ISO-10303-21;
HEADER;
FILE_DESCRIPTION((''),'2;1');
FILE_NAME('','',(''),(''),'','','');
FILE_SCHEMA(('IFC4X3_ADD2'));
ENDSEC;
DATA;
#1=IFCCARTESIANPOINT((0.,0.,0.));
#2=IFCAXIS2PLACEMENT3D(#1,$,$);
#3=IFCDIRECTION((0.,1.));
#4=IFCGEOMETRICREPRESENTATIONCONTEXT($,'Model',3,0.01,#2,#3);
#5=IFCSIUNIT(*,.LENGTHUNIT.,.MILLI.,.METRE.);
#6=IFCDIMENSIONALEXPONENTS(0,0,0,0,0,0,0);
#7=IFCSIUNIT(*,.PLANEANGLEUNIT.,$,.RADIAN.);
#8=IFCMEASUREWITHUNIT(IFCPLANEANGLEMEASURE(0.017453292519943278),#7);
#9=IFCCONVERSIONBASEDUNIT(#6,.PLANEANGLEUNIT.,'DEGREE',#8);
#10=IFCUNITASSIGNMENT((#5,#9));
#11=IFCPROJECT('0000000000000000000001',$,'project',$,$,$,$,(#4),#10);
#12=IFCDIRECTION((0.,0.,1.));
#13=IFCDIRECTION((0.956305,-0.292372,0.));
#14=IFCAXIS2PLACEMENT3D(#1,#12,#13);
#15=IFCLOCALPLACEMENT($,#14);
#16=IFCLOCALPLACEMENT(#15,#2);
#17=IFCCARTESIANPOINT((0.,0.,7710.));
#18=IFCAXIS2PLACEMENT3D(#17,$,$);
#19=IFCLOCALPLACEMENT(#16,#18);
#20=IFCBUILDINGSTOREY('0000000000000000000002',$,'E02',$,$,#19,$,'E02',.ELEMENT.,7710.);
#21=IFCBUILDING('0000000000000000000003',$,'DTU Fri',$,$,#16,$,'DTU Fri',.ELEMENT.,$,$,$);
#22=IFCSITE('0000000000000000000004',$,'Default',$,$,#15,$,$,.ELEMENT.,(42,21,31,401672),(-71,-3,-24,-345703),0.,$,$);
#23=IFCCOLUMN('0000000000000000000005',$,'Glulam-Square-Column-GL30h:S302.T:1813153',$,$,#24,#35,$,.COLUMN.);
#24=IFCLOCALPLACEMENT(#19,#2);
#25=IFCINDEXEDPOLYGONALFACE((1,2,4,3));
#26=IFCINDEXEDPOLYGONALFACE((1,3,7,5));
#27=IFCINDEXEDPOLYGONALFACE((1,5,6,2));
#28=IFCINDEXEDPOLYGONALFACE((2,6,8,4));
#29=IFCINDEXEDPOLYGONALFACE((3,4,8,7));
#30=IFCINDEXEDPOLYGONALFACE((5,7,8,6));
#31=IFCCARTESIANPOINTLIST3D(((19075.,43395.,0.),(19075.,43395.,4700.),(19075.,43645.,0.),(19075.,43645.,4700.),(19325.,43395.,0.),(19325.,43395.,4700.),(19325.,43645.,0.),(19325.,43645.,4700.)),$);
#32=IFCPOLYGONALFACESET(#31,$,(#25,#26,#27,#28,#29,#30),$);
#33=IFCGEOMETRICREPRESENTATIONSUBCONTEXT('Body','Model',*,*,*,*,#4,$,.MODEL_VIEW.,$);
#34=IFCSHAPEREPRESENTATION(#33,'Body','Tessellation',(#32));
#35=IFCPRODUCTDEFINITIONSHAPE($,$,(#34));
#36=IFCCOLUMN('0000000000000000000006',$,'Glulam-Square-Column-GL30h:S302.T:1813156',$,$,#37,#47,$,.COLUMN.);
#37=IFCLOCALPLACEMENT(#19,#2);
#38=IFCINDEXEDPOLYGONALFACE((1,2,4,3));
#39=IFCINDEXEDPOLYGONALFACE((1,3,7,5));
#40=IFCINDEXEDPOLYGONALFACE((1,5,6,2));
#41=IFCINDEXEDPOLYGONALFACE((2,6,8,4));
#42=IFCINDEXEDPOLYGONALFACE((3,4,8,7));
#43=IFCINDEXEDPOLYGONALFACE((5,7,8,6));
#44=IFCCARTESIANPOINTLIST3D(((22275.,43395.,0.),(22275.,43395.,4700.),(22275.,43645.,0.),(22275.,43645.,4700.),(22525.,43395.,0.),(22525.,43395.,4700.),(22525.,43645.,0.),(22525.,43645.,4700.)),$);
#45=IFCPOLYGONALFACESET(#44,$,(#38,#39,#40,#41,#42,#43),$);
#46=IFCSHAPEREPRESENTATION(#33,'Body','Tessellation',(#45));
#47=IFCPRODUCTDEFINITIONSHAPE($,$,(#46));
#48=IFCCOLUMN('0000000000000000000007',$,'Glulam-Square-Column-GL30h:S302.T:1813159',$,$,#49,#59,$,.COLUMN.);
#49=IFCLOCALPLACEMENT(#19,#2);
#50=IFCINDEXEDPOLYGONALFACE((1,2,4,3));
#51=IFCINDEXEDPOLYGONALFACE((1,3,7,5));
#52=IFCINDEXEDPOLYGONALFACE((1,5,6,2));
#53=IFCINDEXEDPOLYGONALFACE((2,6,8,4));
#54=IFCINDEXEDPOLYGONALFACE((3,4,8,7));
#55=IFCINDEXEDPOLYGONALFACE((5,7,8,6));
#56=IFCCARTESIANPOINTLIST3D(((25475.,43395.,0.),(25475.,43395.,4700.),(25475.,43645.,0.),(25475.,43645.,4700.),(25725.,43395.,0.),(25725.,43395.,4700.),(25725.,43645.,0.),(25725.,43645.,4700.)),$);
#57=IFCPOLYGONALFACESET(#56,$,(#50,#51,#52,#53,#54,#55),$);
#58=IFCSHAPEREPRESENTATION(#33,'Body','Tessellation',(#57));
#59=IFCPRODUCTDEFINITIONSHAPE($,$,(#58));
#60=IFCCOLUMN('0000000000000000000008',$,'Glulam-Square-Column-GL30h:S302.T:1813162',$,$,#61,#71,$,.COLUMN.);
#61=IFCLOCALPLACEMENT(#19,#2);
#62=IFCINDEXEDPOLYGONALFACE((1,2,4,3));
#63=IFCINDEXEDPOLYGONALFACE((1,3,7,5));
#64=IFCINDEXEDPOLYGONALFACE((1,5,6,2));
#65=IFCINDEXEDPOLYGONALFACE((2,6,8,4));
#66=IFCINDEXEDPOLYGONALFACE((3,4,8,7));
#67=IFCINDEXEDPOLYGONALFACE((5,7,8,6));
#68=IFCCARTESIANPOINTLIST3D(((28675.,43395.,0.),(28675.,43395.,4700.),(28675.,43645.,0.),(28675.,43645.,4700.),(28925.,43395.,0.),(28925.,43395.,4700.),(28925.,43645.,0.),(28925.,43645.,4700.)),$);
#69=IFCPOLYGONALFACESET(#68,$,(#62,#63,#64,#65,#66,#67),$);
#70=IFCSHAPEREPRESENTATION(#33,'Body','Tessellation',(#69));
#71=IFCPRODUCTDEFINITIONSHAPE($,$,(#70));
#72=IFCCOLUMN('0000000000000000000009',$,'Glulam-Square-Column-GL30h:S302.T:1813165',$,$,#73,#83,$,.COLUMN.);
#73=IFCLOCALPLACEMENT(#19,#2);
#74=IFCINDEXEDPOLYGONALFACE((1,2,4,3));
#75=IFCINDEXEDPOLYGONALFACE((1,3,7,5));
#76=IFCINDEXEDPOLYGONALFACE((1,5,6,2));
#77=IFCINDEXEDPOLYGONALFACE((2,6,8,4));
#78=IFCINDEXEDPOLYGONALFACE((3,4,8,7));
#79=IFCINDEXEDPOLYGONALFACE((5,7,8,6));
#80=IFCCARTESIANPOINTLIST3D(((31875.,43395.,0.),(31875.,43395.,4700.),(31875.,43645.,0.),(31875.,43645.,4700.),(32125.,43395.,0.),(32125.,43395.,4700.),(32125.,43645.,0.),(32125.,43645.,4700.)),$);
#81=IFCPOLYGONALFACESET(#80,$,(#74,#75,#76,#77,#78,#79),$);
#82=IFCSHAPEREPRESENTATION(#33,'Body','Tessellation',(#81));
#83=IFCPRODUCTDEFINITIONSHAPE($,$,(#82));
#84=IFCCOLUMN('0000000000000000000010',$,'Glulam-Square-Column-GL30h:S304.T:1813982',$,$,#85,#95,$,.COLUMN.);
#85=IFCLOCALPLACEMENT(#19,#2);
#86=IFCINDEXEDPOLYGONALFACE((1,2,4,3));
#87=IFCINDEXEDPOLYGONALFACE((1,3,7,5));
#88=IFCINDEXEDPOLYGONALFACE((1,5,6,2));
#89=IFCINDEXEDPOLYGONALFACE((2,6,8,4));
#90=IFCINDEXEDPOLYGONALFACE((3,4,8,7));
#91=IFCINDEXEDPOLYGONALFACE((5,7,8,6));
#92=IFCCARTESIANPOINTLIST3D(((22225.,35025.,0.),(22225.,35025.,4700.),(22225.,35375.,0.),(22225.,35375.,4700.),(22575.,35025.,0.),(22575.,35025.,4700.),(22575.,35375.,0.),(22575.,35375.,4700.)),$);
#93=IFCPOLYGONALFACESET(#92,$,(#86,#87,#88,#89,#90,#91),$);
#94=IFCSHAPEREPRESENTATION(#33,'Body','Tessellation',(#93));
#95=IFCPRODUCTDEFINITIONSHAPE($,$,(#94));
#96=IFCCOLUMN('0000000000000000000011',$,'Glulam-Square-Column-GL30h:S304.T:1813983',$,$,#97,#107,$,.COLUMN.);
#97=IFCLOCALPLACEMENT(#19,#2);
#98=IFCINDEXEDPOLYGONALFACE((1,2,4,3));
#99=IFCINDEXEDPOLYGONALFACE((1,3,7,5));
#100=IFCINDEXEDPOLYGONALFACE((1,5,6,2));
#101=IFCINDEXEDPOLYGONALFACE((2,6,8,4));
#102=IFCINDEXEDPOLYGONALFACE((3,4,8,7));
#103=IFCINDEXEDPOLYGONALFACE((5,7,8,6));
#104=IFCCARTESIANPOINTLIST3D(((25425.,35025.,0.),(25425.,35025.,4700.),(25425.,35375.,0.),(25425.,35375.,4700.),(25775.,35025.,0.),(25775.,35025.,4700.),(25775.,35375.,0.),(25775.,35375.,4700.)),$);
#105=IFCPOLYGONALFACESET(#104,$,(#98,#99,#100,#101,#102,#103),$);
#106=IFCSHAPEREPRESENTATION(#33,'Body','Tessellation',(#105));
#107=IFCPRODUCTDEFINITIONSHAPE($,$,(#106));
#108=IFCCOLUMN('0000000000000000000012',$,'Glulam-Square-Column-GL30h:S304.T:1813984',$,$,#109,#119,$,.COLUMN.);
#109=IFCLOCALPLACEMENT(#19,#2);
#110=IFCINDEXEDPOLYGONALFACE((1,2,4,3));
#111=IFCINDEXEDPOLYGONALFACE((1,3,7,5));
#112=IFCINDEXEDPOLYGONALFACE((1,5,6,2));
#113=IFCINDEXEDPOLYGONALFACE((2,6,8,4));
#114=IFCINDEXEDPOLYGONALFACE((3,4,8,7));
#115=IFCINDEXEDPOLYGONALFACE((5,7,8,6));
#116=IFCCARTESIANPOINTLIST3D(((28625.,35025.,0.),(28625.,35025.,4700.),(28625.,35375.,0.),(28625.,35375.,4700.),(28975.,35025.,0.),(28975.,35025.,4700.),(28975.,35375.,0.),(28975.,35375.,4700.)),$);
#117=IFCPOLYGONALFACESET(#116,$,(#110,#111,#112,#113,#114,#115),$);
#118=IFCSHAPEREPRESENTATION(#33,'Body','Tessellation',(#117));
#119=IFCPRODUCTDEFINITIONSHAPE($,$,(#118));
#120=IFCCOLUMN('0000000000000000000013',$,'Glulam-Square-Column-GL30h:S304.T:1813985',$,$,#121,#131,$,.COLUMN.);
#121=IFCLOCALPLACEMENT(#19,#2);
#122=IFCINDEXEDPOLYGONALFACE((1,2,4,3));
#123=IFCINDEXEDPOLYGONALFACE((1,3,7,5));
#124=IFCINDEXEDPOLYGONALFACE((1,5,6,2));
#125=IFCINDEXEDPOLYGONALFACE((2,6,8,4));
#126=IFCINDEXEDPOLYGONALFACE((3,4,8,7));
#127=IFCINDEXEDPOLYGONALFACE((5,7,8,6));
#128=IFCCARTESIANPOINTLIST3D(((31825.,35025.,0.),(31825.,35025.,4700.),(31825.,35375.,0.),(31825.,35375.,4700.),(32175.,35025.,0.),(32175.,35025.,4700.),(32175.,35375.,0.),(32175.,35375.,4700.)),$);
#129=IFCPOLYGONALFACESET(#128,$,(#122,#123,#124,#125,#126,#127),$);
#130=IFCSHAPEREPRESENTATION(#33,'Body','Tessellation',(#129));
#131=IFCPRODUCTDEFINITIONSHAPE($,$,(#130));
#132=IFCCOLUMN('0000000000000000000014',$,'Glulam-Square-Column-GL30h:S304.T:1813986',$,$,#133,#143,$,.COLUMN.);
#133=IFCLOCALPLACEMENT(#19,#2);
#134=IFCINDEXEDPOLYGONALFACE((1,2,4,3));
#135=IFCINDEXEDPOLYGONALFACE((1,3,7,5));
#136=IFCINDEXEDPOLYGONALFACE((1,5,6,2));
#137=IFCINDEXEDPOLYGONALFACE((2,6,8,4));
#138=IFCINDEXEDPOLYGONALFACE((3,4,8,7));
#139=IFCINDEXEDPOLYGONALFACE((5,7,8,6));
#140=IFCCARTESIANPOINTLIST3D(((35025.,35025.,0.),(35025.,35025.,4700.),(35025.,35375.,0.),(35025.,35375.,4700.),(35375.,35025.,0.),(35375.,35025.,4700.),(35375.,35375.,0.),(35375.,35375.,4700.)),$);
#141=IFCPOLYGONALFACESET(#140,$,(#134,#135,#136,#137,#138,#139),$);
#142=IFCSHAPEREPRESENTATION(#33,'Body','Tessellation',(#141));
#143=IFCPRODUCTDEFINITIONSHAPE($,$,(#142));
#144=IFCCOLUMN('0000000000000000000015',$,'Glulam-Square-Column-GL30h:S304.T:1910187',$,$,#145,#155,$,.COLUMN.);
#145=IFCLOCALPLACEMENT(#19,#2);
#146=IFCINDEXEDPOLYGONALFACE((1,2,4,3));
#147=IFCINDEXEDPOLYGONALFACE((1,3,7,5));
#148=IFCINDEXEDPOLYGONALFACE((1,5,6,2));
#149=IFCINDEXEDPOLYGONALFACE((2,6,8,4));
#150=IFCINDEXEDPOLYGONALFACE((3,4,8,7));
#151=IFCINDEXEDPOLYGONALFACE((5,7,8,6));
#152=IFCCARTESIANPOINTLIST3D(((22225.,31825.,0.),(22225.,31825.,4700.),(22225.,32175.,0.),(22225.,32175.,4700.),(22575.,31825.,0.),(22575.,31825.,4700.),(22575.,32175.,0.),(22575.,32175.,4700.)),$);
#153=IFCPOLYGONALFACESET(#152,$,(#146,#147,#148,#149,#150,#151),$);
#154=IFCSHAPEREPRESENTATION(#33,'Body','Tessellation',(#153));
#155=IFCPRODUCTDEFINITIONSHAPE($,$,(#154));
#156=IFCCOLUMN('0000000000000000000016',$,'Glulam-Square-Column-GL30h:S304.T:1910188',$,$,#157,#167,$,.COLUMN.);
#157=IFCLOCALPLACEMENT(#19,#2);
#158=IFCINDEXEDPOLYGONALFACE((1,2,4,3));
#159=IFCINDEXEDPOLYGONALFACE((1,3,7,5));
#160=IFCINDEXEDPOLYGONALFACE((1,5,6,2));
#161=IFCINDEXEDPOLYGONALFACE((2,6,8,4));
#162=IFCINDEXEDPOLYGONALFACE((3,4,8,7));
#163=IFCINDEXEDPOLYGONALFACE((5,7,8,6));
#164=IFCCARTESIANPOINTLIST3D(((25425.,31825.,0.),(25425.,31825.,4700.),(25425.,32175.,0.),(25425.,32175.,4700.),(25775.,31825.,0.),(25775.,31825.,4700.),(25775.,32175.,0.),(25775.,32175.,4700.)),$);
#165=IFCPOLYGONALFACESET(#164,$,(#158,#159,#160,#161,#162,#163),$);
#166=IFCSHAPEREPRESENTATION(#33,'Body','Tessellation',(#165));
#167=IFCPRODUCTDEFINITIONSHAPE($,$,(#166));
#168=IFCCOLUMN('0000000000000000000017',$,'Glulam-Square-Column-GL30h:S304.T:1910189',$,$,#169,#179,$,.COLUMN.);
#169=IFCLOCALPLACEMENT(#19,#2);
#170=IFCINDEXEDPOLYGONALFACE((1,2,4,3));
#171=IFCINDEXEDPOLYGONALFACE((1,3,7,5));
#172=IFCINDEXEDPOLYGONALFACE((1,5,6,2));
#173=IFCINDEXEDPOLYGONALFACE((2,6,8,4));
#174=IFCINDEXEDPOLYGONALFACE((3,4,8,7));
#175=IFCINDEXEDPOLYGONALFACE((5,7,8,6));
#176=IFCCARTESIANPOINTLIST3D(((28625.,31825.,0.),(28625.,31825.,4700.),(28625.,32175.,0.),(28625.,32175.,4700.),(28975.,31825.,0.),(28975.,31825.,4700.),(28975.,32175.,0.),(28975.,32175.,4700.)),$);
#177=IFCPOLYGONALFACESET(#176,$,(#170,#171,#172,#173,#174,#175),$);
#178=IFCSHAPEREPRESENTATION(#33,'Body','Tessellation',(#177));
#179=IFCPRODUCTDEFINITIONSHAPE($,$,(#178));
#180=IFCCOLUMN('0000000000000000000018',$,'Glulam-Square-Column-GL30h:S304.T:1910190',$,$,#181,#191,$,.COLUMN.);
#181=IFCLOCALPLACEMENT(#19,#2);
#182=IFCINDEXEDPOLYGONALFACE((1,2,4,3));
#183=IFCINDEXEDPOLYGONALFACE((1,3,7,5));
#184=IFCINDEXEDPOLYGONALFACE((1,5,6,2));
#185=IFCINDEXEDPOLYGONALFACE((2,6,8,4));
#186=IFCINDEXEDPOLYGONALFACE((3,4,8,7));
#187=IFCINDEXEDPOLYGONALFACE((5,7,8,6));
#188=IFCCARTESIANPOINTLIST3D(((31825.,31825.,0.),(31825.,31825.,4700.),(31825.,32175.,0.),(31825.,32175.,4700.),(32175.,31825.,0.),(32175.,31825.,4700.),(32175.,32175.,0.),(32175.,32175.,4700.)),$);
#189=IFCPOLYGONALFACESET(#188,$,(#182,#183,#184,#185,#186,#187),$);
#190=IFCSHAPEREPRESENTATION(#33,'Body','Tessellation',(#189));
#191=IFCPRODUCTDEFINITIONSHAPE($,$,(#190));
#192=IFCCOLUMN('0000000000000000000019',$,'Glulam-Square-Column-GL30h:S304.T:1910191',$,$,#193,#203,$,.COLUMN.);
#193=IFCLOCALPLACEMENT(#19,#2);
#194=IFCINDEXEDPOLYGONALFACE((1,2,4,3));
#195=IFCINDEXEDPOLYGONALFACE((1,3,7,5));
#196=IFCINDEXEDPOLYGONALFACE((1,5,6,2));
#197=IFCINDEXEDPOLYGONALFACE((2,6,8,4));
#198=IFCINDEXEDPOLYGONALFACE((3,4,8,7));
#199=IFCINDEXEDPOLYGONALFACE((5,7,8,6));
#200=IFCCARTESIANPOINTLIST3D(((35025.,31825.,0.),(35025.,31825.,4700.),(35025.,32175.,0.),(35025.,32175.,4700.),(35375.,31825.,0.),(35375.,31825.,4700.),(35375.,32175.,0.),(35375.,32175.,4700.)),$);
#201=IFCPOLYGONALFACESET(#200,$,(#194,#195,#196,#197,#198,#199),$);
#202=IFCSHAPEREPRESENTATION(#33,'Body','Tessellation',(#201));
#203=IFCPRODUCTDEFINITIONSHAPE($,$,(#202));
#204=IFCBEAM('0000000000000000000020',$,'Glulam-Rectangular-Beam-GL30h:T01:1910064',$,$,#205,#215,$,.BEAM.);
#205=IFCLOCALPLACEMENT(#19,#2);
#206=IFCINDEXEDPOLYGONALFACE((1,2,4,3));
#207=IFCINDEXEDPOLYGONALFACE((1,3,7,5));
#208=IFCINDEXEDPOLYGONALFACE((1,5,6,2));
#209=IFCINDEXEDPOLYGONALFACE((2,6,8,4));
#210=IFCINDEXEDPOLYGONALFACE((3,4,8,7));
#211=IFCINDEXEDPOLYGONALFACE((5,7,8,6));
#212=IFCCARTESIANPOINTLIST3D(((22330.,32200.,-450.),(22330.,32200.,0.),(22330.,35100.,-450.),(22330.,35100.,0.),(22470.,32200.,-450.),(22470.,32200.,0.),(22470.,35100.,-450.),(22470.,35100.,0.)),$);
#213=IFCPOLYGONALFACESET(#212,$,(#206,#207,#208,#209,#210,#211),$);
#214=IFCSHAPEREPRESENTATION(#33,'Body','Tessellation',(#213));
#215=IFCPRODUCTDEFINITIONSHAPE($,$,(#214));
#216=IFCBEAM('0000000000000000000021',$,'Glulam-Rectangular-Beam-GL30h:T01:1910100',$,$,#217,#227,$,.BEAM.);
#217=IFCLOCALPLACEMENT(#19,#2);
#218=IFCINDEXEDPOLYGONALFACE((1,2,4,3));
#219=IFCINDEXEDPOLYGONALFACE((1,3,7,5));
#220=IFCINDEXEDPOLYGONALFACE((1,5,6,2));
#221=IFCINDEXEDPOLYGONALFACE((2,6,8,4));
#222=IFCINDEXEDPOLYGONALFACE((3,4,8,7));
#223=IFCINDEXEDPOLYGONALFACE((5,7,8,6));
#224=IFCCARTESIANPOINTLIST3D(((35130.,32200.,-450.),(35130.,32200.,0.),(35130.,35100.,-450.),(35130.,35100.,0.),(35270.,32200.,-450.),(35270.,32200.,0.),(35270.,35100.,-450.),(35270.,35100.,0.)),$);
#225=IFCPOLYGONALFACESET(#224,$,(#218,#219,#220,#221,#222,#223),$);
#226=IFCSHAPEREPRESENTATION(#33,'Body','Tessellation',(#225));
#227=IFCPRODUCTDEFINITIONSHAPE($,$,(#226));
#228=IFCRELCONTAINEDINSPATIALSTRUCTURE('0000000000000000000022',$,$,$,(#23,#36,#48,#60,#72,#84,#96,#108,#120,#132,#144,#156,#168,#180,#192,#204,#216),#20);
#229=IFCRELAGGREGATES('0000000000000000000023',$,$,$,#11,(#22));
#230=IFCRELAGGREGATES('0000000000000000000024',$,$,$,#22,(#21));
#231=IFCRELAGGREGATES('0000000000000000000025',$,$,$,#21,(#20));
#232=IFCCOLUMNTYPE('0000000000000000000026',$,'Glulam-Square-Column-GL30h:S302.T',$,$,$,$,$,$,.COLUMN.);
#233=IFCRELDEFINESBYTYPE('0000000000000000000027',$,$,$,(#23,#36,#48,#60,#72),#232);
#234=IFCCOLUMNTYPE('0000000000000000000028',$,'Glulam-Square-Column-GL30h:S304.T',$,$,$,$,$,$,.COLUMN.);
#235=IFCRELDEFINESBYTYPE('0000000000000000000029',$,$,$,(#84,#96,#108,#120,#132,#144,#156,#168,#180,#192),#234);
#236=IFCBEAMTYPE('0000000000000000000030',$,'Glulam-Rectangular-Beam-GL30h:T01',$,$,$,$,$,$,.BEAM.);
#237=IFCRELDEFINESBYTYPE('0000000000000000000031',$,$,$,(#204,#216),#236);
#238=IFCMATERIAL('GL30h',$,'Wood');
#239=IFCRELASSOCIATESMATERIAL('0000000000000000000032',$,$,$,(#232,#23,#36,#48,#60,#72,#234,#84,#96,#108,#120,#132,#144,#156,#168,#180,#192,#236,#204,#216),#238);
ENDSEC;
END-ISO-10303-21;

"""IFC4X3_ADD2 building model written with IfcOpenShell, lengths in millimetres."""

from ifc_helpers import new_model, entity, si_unit, converted_unit, direction, frame, origin, origin_2d_with_axis, place, context, subcontext, project, spatial, rectangle, extrude, source, transform, mapped, material, material_profile, profile_set, profile_usage, type_object, type_shapes, element, save


model = new_model("IFC4X3_ADD2")

# Units and contexts
model_context = context("Model", 3, precision=0.01, world=origin(), true_north=direction((0.0, 1.0)))
body_context = subcontext(model_context, "Body", "Model", "MODEL_VIEW")
ifc_project = project(units=[si_unit("LENGTHUNIT", "METRE", prefix="MILLI"), converted_unit("PLANEANGLEUNIT", "DEGREE", entity("IfcPlaneAngleMeasure", 0.017453292519943278), si_unit("PLANEANGLEUNIT", "RADIAN"), dimensions=[0, 0, 0, 0, 0, 0, 0])], contexts=[model_context])

# Site, building, storey
site_placement = place(None, frame((0.0, 0.0, 0.0), z_axis=(0.0, 0.0, 1.0), x_axis=(0.956305, -0.292372, 0.0)))
site = spatial("IfcSite", under=ifc_project, at=site_placement, Name="Default", CompositionType="ELEMENT", RefLatitude=(42, 21, 31, 401672), RefLongitude=(-71, -3, -24, -345703), RefElevation=0.0)
building_placement = place(site_placement, origin())
building = spatial("IfcBuilding", under=site, at=building_placement, Name="DTU Fri", LongName="DTU Fri", CompositionType="ELEMENT")
storey_placement = place(building_placement, frame((0.0, 0.0, 7710.0)))
storey = spatial("IfcBuildingStorey", under=building, at=storey_placement, Name="E02", LongName="E02", CompositionType="ELEMENT", Elevation=7710.0)

# Columns
ifc_material_1 = material(Name="GL30h", Category="Wood")
ifc_material_profile_1 = material_profile(ifc_material_1, rectangle(XDim=250.0, YDim=250.0, at=origin_2d_with_axis()), Name="S302.T")
ifc_profile_set_1 = profile_set([ifc_material_profile_1], Name="S302.T")
ifc_profile_usage_1 = profile_usage(ifc_profile_set_1)
column_type_1 = type_object("IfcColumnType", Name="Glulam-Square-Column-GL30h:S302.T", PredefinedType="COLUMN", material=ifc_profile_set_1)
shared_shape_1 = source(origin(), body_context, "Body", "SweptSolid", [
    extrude(rectangle(XDim=250.0, YDim=250.0, at=origin_2d_with_axis()), frame((0.0, 0.0, 7710.0), z_axis=(0.0, 0.0, 1.0), x_axis=(0.0, 1.0, 0.0)), (0.0, 0.0, 1.0), 4700.0),
])
type_shapes(column_type_1, [shared_shape_1])
for number, where, name in (
    (1, (19200.0, 43520.0, -7710.0), "Glulam-Square-Column-GL30h:S302.T:1813153"),
    (2, (22400.0, 43520.0, -7710.0), "Glulam-Square-Column-GL30h:S302.T:1813156"),
    (3, (25600.0, 43520.0, -7710.0), "Glulam-Square-Column-GL30h:S302.T:1813159"),
    (4, (28800.0, 43520.0, -7710.0), "Glulam-Square-Column-GL30h:S302.T:1813162"),
    (5, (32000.0, 43520.0, -7710.0), "Glulam-Square-Column-GL30h:S302.T:1813165"),
):
    element("IfcColumn", number, at=place(storey_placement, frame(where)), inside=storey, type_object=column_type_1, material=ifc_profile_usage_1, Name=name, PredefinedType="COLUMN", context=body_context, shape_type="MappedRepresentation", body=[
        mapped(shared_shape_1, transform((0.0, 0.0, 0.0), scale=1.0)),
    ])
ifc_material_profile_2 = material_profile(ifc_material_1, rectangle(XDim=350.0, YDim=350.0, at=origin_2d_with_axis()), Name="S304.T")
ifc_profile_set_2 = profile_set([ifc_material_profile_2], Name="S304.T")
ifc_profile_usage_2 = profile_usage(ifc_profile_set_2)
column_type_2 = type_object("IfcColumnType", Name="Glulam-Square-Column-GL30h:S304.T", PredefinedType="COLUMN", material=ifc_profile_set_2)
shared_shape_2 = source(origin(), body_context, "Body", "SweptSolid", [
    extrude(rectangle(XDim=350.0, YDim=350.0, at=origin_2d_with_axis()), frame((0.0, 0.0, 7710.0), z_axis=(0.0, 0.0, 1.0), x_axis=(0.0, 1.0, 0.0)), (0.0, 0.0, 1.0), 4700.0),
])
type_shapes(column_type_2, [shared_shape_2])
for number, where, name in (
    (6, (22400.0, 35200.0, -7710.0), "Glulam-Square-Column-GL30h:S304.T:1813982"),
    (7, (25600.0, 35200.0, -7710.0), "Glulam-Square-Column-GL30h:S304.T:1813983"),
    (8, (28800.0, 35200.0, -7710.0), "Glulam-Square-Column-GL30h:S304.T:1813984"),
    (9, (32000.0, 35200.0, -7710.0), "Glulam-Square-Column-GL30h:S304.T:1813985"),
    (10, (35200.0, 35200.0, -7710.0), "Glulam-Square-Column-GL30h:S304.T:1813986"),
    (11, (22400.0, 32000.0, -7710.0), "Glulam-Square-Column-GL30h:S304.T:1910187"),
    (12, (25600.0, 32000.0, -7710.0), "Glulam-Square-Column-GL30h:S304.T:1910188"),
    (13, (28800.0, 32000.0, -7710.0), "Glulam-Square-Column-GL30h:S304.T:1910189"),
    (14, (32000.0, 32000.0, -7710.0), "Glulam-Square-Column-GL30h:S304.T:1910190"),
    (15, (35200.0, 32000.0, -7710.0), "Glulam-Square-Column-GL30h:S304.T:1910191"),
):
    element("IfcColumn", number, at=place(storey_placement, frame(where)), inside=storey, type_object=column_type_2, material=ifc_profile_usage_2, Name=name, PredefinedType="COLUMN", context=body_context, shape_type="MappedRepresentation", body=[
        mapped(shared_shape_2, transform((0.0, 0.0, 0.0), scale=1.0)),
    ])

# Beams
ifc_material_profile_3 = material_profile(ifc_material_1, rectangle(XDim=450.0, YDim=140.0, at=origin_2d_with_axis()), Name="T01")
ifc_profile_set_3 = profile_set([ifc_material_profile_3], Name="T01")
ifc_profile_usage_3 = profile_usage(ifc_profile_set_3, cardinal=8)
beam_type_1 = type_object("IfcBeamType", Name="Glulam-Rectangular-Beam-GL30h:T01", PredefinedType="BEAM", material=ifc_profile_set_3)
shared_shape_3 = source(origin(), body_context, "Body", "SweptSolid", [
    extrude(rectangle(XDim=450.0, YDim=140.0, at=origin_2d_with_axis()), frame((-1400.0, 0.0, 0.0), z_axis=(1.0, 0.0, 0.0), x_axis=(0.0, 0.0, -1.0)), (0.0, 0.0, 1.0), 2900.0),
])
type_shapes(beam_type_1, [shared_shape_3])
for number, where, z_axis, x_axis, name in (
    (16, (22400.0, 33600.0, -225.0), (0.0, 0.0, 1.0), (0.0, 1.0, 0.0), "Glulam-Rectangular-Beam-GL30h:T01:1910064"),
    (17, (35200.0, 33600.0, -225.0), (0.0, 0.0, 1.0), (0.0, 1.0, 0.0), "Glulam-Rectangular-Beam-GL30h:T01:1910100"),
):
    element("IfcBeam", number, at=place(storey_placement, frame(where, z_axis=z_axis, x_axis=x_axis)), inside=storey, type_object=beam_type_1, material=ifc_profile_usage_3, Name=name, PredefinedType="BEAM", context=body_context, shape_type="MappedRepresentation", body=[
        mapped(shared_shape_3, transform((0.0, 0.0, 0.0), scale=1.0)),
    ])

save(model, "model.ifc")
